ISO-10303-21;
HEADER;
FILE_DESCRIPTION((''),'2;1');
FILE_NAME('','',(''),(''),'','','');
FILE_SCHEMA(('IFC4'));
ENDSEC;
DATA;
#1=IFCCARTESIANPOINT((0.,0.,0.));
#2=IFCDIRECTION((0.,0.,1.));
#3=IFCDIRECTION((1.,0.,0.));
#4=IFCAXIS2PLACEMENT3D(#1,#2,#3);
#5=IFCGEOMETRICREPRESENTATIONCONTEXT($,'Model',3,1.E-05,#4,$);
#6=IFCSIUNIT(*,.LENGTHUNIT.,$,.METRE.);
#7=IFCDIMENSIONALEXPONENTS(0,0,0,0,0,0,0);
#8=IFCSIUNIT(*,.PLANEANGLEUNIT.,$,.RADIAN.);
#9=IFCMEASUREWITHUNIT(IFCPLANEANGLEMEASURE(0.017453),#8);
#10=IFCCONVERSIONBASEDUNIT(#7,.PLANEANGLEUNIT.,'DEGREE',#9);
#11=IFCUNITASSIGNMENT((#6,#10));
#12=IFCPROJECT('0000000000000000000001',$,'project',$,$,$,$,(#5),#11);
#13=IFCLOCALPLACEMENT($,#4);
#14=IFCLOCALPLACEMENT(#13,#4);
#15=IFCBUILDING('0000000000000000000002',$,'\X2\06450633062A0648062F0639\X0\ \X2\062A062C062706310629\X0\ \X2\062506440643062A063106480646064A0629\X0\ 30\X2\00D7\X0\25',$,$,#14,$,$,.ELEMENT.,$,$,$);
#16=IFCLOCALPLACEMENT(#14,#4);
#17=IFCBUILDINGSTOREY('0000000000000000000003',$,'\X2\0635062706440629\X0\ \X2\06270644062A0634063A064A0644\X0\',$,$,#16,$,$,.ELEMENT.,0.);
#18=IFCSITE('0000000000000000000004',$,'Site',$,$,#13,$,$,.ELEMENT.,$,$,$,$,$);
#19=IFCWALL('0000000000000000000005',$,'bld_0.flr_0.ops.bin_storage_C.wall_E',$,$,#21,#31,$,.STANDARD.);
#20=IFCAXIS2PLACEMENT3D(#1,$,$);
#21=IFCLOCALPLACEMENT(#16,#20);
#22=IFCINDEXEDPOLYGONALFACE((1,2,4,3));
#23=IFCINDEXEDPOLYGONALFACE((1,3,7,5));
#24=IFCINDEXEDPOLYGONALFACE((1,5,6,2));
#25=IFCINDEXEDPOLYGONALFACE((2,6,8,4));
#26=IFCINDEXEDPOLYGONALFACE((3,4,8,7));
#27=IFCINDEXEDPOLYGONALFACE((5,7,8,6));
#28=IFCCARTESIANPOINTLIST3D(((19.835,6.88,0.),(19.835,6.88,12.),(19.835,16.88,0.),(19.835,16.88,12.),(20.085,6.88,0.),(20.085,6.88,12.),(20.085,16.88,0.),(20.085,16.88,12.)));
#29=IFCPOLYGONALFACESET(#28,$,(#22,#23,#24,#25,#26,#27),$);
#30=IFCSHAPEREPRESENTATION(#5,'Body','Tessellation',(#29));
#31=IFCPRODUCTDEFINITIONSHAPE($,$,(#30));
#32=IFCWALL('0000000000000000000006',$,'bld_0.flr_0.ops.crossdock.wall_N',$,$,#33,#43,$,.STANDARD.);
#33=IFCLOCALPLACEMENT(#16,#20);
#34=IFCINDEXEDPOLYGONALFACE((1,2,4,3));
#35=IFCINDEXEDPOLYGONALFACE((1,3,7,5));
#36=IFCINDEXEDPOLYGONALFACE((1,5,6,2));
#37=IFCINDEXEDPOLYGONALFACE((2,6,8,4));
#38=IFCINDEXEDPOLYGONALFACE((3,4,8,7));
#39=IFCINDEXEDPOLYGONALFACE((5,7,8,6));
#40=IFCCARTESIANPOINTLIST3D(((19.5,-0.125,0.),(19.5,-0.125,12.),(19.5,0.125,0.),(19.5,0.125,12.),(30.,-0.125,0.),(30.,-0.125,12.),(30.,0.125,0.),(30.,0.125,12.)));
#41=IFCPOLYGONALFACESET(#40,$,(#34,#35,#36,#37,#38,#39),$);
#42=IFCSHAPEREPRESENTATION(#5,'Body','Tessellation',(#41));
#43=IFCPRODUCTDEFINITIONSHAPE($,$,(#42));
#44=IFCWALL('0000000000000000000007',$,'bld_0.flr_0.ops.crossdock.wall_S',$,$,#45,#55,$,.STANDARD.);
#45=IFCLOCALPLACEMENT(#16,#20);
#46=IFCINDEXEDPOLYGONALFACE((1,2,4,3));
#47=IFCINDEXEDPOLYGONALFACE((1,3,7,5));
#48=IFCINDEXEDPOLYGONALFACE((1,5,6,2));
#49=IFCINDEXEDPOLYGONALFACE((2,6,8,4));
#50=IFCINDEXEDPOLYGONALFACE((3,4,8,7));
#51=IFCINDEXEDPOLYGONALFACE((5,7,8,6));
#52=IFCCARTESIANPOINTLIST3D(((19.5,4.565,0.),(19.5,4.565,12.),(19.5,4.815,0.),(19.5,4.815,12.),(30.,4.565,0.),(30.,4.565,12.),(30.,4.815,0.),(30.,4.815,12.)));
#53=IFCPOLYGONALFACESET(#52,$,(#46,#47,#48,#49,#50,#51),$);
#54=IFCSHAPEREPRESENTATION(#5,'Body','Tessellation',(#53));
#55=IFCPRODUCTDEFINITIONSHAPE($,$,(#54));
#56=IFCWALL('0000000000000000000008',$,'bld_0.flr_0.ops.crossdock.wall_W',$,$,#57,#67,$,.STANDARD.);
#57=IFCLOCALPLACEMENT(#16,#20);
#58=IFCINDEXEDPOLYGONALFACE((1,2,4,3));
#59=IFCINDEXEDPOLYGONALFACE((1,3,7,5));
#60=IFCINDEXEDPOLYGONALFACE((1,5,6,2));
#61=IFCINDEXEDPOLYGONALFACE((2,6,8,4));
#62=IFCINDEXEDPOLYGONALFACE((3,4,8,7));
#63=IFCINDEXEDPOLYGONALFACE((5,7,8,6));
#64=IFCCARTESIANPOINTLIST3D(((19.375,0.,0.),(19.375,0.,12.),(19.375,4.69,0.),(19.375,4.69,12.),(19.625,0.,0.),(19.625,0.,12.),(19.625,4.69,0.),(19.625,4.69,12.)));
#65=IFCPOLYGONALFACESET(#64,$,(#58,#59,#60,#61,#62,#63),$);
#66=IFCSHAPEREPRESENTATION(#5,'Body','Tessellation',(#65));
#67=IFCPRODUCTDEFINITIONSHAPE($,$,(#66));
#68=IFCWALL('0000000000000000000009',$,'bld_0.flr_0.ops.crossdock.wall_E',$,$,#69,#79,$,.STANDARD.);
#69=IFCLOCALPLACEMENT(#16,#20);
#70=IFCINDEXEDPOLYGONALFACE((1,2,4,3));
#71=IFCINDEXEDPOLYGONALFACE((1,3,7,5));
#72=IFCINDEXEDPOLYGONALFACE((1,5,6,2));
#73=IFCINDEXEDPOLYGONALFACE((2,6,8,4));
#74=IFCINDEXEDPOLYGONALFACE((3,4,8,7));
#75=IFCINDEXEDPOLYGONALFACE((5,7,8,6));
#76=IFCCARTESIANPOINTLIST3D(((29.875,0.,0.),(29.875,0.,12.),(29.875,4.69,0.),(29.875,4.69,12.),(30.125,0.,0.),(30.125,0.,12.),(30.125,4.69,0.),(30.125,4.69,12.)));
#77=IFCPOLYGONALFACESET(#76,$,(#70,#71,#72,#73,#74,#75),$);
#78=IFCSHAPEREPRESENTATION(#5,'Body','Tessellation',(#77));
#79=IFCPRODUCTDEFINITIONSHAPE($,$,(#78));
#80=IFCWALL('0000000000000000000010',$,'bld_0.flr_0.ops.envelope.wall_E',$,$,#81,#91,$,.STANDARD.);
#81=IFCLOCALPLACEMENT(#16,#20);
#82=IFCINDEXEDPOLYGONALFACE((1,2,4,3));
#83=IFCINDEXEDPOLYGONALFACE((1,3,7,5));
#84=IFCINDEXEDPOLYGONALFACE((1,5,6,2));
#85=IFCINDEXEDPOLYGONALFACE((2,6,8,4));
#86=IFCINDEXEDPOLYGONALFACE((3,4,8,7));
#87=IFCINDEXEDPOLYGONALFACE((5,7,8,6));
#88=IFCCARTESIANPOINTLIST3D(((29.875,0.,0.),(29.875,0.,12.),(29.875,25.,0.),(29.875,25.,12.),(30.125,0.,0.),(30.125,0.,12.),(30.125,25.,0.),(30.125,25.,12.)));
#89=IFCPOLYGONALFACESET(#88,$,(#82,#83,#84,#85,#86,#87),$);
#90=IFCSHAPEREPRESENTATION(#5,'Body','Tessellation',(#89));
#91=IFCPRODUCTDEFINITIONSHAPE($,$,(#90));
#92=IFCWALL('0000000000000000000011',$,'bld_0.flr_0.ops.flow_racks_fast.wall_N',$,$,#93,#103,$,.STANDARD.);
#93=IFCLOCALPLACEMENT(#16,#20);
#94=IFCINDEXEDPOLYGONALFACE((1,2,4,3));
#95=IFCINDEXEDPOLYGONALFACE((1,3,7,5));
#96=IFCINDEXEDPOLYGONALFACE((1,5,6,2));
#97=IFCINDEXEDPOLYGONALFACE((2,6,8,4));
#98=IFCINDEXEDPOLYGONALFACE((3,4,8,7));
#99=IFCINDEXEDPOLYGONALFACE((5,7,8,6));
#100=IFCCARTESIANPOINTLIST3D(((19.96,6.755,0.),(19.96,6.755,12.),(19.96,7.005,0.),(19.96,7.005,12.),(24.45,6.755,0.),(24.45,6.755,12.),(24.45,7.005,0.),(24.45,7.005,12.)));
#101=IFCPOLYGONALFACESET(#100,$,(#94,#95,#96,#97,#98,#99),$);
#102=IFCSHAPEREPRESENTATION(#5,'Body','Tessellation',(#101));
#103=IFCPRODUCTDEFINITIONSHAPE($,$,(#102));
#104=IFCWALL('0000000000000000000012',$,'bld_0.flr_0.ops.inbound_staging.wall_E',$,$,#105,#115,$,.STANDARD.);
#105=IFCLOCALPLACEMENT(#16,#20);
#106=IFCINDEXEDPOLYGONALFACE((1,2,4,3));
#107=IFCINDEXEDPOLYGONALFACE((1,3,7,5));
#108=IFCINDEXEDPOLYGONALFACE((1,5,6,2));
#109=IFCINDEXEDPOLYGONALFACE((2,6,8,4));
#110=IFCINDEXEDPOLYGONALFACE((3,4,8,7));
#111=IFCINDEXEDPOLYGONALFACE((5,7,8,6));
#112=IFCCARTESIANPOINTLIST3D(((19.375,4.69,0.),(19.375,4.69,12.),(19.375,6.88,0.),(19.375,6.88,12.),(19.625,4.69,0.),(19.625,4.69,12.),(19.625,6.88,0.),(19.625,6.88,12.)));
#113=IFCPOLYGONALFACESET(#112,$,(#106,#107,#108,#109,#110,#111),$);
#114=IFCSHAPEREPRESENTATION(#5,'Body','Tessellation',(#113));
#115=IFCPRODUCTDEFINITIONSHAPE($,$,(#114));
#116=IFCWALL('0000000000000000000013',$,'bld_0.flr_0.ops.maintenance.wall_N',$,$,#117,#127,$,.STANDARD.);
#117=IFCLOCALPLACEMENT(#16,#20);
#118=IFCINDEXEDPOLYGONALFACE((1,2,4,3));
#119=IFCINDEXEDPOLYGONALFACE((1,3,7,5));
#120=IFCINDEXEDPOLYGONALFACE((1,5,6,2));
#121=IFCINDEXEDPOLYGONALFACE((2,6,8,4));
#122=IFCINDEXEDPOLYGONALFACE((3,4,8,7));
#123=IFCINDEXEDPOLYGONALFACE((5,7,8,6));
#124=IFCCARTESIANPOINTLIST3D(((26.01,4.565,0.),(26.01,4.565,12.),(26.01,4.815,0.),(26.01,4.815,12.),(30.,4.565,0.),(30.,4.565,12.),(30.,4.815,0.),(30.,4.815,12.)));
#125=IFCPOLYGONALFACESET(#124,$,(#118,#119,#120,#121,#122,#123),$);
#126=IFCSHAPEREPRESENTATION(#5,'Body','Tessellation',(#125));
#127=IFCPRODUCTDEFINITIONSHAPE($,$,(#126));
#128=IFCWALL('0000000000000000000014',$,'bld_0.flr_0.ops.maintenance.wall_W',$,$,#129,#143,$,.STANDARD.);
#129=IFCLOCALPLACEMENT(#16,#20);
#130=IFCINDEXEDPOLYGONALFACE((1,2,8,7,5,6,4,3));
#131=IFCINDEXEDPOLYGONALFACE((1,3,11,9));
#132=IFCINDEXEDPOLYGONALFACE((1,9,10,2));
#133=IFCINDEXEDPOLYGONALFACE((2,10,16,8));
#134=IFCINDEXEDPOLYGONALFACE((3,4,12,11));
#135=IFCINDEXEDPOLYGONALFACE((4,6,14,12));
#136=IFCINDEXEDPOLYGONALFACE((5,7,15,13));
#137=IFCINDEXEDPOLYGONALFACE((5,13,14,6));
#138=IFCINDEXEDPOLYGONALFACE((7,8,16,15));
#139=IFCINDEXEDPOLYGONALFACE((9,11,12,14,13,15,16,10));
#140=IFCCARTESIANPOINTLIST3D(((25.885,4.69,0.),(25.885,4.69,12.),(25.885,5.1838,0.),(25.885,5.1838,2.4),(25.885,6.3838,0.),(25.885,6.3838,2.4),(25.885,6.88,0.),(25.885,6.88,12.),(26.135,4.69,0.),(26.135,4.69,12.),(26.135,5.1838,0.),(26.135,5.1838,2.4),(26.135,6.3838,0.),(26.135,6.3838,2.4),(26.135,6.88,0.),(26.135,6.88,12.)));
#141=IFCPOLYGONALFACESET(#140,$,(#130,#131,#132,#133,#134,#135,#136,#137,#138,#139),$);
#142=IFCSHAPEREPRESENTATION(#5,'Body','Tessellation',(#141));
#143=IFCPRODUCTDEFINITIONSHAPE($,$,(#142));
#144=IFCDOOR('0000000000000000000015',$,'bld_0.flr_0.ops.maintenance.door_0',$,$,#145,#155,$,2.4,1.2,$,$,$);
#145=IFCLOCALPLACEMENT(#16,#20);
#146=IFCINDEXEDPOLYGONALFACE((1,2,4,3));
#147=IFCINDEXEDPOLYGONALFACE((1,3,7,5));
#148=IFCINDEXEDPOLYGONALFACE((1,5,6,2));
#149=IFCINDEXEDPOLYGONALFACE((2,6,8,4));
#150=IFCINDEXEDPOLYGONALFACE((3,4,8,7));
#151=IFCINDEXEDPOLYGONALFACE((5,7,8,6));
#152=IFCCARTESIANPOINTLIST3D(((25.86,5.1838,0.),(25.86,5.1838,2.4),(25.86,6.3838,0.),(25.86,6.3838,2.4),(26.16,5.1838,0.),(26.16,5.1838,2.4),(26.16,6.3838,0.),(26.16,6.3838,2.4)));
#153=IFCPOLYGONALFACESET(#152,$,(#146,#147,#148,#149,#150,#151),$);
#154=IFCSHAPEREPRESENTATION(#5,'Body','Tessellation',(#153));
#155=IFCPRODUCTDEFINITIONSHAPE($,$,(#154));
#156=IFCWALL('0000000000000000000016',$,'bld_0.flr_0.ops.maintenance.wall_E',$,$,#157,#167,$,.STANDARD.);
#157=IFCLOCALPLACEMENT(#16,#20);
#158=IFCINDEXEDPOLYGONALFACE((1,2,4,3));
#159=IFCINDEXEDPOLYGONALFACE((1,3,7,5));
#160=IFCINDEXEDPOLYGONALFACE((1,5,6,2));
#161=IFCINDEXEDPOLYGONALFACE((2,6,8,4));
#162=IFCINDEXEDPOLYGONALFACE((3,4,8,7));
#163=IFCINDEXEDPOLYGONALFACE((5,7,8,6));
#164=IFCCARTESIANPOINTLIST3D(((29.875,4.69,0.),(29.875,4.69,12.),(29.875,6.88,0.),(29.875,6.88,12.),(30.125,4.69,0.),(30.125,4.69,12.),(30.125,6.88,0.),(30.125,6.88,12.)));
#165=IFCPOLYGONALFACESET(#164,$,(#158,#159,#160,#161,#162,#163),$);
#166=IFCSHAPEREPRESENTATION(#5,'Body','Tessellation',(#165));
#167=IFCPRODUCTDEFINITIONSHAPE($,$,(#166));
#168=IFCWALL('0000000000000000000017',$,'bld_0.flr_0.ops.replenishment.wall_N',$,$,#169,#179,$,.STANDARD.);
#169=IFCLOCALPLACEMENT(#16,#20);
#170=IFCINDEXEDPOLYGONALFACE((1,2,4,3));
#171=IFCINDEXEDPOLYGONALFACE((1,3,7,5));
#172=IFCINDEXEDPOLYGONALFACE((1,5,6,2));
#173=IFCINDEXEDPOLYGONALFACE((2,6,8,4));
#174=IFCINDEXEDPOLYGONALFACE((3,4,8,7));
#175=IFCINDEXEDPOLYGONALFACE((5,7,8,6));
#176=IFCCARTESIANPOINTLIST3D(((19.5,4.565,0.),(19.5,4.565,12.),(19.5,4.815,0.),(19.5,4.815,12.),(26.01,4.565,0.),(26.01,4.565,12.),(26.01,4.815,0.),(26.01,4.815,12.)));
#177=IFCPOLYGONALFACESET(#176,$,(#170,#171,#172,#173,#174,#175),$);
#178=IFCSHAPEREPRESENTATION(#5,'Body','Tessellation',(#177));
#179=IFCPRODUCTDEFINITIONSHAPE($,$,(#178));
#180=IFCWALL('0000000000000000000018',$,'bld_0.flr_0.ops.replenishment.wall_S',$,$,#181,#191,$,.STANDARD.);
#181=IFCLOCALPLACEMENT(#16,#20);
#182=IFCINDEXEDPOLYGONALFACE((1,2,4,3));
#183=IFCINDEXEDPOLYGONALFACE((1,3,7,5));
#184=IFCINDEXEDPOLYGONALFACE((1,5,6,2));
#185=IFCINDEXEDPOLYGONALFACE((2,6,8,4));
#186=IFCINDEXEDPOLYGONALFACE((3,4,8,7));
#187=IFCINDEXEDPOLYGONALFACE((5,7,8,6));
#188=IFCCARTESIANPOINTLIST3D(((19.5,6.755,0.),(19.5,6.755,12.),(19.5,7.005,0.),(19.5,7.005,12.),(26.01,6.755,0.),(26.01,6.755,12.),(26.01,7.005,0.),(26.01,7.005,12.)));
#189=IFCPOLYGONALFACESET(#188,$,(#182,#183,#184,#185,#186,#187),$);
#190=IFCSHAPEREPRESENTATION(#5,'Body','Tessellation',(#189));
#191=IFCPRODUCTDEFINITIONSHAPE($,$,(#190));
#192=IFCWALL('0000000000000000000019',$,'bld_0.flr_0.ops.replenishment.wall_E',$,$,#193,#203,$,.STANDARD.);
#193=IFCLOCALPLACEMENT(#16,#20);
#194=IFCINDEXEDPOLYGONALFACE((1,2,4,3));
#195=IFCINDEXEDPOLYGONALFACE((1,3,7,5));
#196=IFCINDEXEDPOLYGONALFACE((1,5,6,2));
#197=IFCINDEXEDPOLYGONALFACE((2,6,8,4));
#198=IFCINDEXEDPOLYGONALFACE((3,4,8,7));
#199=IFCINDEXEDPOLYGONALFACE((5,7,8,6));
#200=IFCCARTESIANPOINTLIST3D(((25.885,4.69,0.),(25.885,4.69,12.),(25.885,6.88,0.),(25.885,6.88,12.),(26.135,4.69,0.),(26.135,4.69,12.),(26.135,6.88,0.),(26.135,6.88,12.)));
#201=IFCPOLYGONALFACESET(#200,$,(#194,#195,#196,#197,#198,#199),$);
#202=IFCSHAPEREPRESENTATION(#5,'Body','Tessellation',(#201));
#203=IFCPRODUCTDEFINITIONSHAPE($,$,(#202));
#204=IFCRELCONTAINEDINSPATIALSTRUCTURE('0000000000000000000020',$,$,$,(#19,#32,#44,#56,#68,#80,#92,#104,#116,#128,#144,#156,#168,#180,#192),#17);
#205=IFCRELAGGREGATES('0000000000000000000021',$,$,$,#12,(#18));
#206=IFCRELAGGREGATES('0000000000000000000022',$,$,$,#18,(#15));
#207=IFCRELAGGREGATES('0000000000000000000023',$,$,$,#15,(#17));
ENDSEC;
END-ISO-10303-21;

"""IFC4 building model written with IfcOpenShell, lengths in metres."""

from ifc_helpers import new_model, entity, si_unit, converted_unit, frame, frame_2d, origin_with_axes, origin_2d_with_axis, place, context, project, spatial, rectangle, extrude, element, fill, save


model = new_model("IFC4")

# Units and contexts
model_context = context("Model", 3, precision=1e-05, world=origin_with_axes())
ifc_project = project(units=[si_unit("LENGTHUNIT", "METRE"), converted_unit("PLANEANGLEUNIT", "DEGREE", entity("IfcPlaneAngleMeasure", 0.017453), si_unit("PLANEANGLEUNIT", "RADIAN"), dimensions=[0, 0, 0, 0, 0, 0, 0])], contexts=[model_context])

# Site, building, storey
site_placement = place(None, origin_with_axes())
site = spatial("IfcSite", under=ifc_project, at=site_placement, Name="Site", CompositionType="ELEMENT")
building_placement = place(site_placement, origin_with_axes())
building = spatial("IfcBuilding", under=site, at=building_placement, Name="مستودع تجارة إلكترونية 30×25", CompositionType="ELEMENT")
storey_placement = place(building_placement, origin_with_axes())
storey = spatial("IfcBuildingStorey", under=building, at=storey_placement, Name="صالة التشغيل", CompositionType="ELEMENT", Elevation=0.0)

# Walls
wall_1_placement = place(storey_placement, frame((19.96, 6.88, 0.0), z_axis=(0.0, 0.0, 1.0), x_axis=(0.0, 1.0, 0.0)))
element("IfcWall", 1, at=wall_1_placement, inside=storey, Name="bld_0.flr_0.ops.bin_storage_C.wall_E", PredefinedType="STANDARD", context=model_context, shape_type="SweptSolid", body=[
    extrude(rectangle(XDim=10.0, YDim=0.25, at=frame_2d((5.0, 0.0), x_axis=(1.0, 0.0))), origin_with_axes(), (0.0, 0.0, 1.0), 12.0),
])
for number, where, z_axis, x_axis, name in (
    (2, (19.5, 0.0, 0.0), (0.0, 0.0, 1.0), (1.0, 0.0, 0.0), "bld_0.flr_0.ops.crossdock.wall_N"),
    (3, (19.5, 4.69, 0.0), (0.0, 0.0, 1.0), (1.0, 0.0, 0.0), "bld_0.flr_0.ops.crossdock.wall_S"),
):
    element("IfcWall", number, at=place(storey_placement, frame(where, z_axis=z_axis, x_axis=x_axis)), inside=storey, Name=name, PredefinedType="STANDARD", context=model_context, shape_type="SweptSolid", body=[
        extrude(rectangle(XDim=10.5, YDim=0.25, at=frame_2d((5.25, 0.0), x_axis=(1.0, 0.0))), origin_with_axes(), (0.0, 0.0, 1.0), 12.0),
    ])
for number, where, z_axis, x_axis, name in (
    (4, (19.5, 0.0, 0.0), (0.0, 0.0, 1.0), (0.0, 1.0, 0.0), "bld_0.flr_0.ops.crossdock.wall_W"),
    (5, (30.0, 0.0, 0.0), (0.0, 0.0, 1.0), (0.0, 1.0, 0.0), "bld_0.flr_0.ops.crossdock.wall_E"),
):
    element("IfcWall", number, at=place(storey_placement, frame(where, z_axis=z_axis, x_axis=x_axis)), inside=storey, Name=name, PredefinedType="STANDARD", context=model_context, shape_type="SweptSolid", body=[
        extrude(rectangle(XDim=4.69, YDim=0.25, at=frame_2d((2.345, 0.0), x_axis=(1.0, 0.0))), origin_with_axes(), (0.0, 0.0, 1.0), 12.0),
    ])
wall_2_placement = place(storey_placement, frame((30.0, 0.0, 0.0), z_axis=(0.0, 0.0, 1.0), x_axis=(0.0, 1.0, 0.0)))
element("IfcWall", 6, at=wall_2_placement, inside=storey, Name="bld_0.flr_0.ops.envelope.wall_E", PredefinedType="STANDARD", context=model_context, shape_type="SweptSolid", body=[
    extrude(rectangle(XDim=25.0, YDim=0.25, at=frame_2d((12.5, 0.0), x_axis=(1.0, 0.0))), origin_with_axes(), (0.0, 0.0, 1.0), 12.0),
])
wall_3_placement = place(storey_placement, frame((19.96, 6.88, 0.0), z_axis=(0.0, 0.0, 1.0), x_axis=(1.0, 0.0, 0.0)))
element("IfcWall", 7, at=wall_3_placement, inside=storey, Name="bld_0.flr_0.ops.flow_racks_fast.wall_N", PredefinedType="STANDARD", context=model_context, shape_type="SweptSolid", body=[
    extrude(rectangle(XDim=4.49, YDim=0.25, at=frame_2d((2.245, 0.0), x_axis=(1.0, 0.0))), origin_with_axes(), (0.0, 0.0, 1.0), 12.0),
])
wall_4_placement = place(storey_placement, frame((19.5, 4.69, 0.0), z_axis=(0.0, 0.0, 1.0), x_axis=(0.0, 1.0, 0.0)))
element("IfcWall", 8, at=wall_4_placement, inside=storey, Name="bld_0.flr_0.ops.inbound_staging.wall_E", PredefinedType="STANDARD", context=model_context, shape_type="SweptSolid", body=[
    extrude(rectangle(XDim=2.19, YDim=0.25, at=frame_2d((1.095, 0.0), x_axis=(1.0, 0.0))), origin_with_axes(), (0.0, 0.0, 1.0), 12.0),
])
wall_5_placement = place(storey_placement, frame((26.01, 4.69, 0.0), z_axis=(0.0, 0.0, 1.0), x_axis=(1.0, 0.0, 0.0)))
element("IfcWall", 9, at=wall_5_placement, inside=storey, Name="bld_0.flr_0.ops.maintenance.wall_N", PredefinedType="STANDARD", context=model_context, shape_type="SweptSolid", body=[
    extrude(rectangle(XDim=3.99, YDim=0.25, at=frame_2d((1.995, 0.0), x_axis=(1.0, 0.0))), origin_with_axes(), (0.0, 0.0, 1.0), 12.0),
])

# Wall, opening, door
wall_6_placement = place(storey_placement, frame((26.01, 4.69, 0.0), z_axis=(0.0, 0.0, 1.0), x_axis=(0.0, 1.0, 0.0)))
wall_6 = element("IfcWall", 10, at=wall_6_placement, inside=storey, Name="bld_0.flr_0.ops.maintenance.wall_W", PredefinedType="STANDARD", context=model_context, shape_type="SweptSolid", body=[
    extrude(rectangle(XDim=2.19, YDim=0.25, at=frame_2d((1.095, 0.0), x_axis=(1.0, 0.0))), origin_with_axes(), (0.0, 0.0, 1.0), 12.0),
])
opening_placement = place(storey_placement, frame((26.01, 5.7838, 0.0), z_axis=(0.0, 0.0, 1.0), x_axis=(0.0, 1.0, 0.0)))
opening = element("IfcOpeningElement", 11, at=opening_placement, cuts=wall_6, PredefinedType="OPENING", context=model_context, shape_type="SweptSolid", body=[
    extrude(rectangle(XDim=1.2, YDim=0.3, at=origin_2d_with_axis()), origin_with_axes(), (0.0, 0.0, 1.0), 2.4),
])
door_placement = place(storey_placement, frame((26.01, 5.7838, 0.0), z_axis=(0.0, 0.0, 1.0), x_axis=(0.0, 1.0, 0.0)))
door = element("IfcDoor", 12, at=door_placement, inside=storey, Name="bld_0.flr_0.ops.maintenance.door_0", OverallHeight=2.4, OverallWidth=1.2, context=model_context, shape_type="SweptSolid", body=[
    extrude(rectangle(XDim=1.2, YDim=0.3, at=origin_2d_with_axis()), origin_with_axes(), (0.0, 0.0, 1.0), 2.4),
])
fill(opening, door)

# Walls
wall_7_placement = place(storey_placement, frame((30.0, 4.69, 0.0), z_axis=(0.0, 0.0, 1.0), x_axis=(0.0, 1.0, 0.0)))
element("IfcWall", 13, at=wall_7_placement, inside=storey, Name="bld_0.flr_0.ops.maintenance.wall_E", PredefinedType="STANDARD", context=model_context, shape_type="SweptSolid", body=[
    extrude(rectangle(XDim=2.19, YDim=0.25, at=frame_2d((1.095, 0.0), x_axis=(1.0, 0.0))), origin_with_axes(), (0.0, 0.0, 1.0), 12.0),
])
for number, where, z_axis, x_axis, name in (
    (14, (19.5, 4.69, 0.0), (0.0, 0.0, 1.0), (1.0, 0.0, 0.0), "bld_0.flr_0.ops.replenishment.wall_N"),
    (15, (19.5, 6.88, 0.0), (0.0, 0.0, 1.0), (1.0, 0.0, 0.0), "bld_0.flr_0.ops.replenishment.wall_S"),
):
    element("IfcWall", number, at=place(storey_placement, frame(where, z_axis=z_axis, x_axis=x_axis)), inside=storey, Name=name, PredefinedType="STANDARD", context=model_context, shape_type="SweptSolid", body=[
        extrude(rectangle(XDim=6.51, YDim=0.25, at=frame_2d((3.255, 0.0), x_axis=(1.0, 0.0))), origin_with_axes(), (0.0, 0.0, 1.0), 12.0),
    ])
for number, where, z_axis, x_axis, name in (
    (16, (26.01, 4.69, 0.0), (0.0, 0.0, 1.0), (0.0, 1.0, 0.0), "bld_0.flr_0.ops.replenishment.wall_E"),
):
    element("IfcWall", number, at=place(storey_placement, frame(where, z_axis=z_axis, x_axis=x_axis)), inside=storey, Name=name, PredefinedType="STANDARD", context=model_context, shape_type="SweptSolid", body=[
        extrude(rectangle(XDim=2.19, YDim=0.25, at=frame_2d((1.095, 0.0), x_axis=(1.0, 0.0))), origin_with_axes(), (0.0, 0.0, 1.0), 12.0),
    ])

save(model, "model.ifc")
